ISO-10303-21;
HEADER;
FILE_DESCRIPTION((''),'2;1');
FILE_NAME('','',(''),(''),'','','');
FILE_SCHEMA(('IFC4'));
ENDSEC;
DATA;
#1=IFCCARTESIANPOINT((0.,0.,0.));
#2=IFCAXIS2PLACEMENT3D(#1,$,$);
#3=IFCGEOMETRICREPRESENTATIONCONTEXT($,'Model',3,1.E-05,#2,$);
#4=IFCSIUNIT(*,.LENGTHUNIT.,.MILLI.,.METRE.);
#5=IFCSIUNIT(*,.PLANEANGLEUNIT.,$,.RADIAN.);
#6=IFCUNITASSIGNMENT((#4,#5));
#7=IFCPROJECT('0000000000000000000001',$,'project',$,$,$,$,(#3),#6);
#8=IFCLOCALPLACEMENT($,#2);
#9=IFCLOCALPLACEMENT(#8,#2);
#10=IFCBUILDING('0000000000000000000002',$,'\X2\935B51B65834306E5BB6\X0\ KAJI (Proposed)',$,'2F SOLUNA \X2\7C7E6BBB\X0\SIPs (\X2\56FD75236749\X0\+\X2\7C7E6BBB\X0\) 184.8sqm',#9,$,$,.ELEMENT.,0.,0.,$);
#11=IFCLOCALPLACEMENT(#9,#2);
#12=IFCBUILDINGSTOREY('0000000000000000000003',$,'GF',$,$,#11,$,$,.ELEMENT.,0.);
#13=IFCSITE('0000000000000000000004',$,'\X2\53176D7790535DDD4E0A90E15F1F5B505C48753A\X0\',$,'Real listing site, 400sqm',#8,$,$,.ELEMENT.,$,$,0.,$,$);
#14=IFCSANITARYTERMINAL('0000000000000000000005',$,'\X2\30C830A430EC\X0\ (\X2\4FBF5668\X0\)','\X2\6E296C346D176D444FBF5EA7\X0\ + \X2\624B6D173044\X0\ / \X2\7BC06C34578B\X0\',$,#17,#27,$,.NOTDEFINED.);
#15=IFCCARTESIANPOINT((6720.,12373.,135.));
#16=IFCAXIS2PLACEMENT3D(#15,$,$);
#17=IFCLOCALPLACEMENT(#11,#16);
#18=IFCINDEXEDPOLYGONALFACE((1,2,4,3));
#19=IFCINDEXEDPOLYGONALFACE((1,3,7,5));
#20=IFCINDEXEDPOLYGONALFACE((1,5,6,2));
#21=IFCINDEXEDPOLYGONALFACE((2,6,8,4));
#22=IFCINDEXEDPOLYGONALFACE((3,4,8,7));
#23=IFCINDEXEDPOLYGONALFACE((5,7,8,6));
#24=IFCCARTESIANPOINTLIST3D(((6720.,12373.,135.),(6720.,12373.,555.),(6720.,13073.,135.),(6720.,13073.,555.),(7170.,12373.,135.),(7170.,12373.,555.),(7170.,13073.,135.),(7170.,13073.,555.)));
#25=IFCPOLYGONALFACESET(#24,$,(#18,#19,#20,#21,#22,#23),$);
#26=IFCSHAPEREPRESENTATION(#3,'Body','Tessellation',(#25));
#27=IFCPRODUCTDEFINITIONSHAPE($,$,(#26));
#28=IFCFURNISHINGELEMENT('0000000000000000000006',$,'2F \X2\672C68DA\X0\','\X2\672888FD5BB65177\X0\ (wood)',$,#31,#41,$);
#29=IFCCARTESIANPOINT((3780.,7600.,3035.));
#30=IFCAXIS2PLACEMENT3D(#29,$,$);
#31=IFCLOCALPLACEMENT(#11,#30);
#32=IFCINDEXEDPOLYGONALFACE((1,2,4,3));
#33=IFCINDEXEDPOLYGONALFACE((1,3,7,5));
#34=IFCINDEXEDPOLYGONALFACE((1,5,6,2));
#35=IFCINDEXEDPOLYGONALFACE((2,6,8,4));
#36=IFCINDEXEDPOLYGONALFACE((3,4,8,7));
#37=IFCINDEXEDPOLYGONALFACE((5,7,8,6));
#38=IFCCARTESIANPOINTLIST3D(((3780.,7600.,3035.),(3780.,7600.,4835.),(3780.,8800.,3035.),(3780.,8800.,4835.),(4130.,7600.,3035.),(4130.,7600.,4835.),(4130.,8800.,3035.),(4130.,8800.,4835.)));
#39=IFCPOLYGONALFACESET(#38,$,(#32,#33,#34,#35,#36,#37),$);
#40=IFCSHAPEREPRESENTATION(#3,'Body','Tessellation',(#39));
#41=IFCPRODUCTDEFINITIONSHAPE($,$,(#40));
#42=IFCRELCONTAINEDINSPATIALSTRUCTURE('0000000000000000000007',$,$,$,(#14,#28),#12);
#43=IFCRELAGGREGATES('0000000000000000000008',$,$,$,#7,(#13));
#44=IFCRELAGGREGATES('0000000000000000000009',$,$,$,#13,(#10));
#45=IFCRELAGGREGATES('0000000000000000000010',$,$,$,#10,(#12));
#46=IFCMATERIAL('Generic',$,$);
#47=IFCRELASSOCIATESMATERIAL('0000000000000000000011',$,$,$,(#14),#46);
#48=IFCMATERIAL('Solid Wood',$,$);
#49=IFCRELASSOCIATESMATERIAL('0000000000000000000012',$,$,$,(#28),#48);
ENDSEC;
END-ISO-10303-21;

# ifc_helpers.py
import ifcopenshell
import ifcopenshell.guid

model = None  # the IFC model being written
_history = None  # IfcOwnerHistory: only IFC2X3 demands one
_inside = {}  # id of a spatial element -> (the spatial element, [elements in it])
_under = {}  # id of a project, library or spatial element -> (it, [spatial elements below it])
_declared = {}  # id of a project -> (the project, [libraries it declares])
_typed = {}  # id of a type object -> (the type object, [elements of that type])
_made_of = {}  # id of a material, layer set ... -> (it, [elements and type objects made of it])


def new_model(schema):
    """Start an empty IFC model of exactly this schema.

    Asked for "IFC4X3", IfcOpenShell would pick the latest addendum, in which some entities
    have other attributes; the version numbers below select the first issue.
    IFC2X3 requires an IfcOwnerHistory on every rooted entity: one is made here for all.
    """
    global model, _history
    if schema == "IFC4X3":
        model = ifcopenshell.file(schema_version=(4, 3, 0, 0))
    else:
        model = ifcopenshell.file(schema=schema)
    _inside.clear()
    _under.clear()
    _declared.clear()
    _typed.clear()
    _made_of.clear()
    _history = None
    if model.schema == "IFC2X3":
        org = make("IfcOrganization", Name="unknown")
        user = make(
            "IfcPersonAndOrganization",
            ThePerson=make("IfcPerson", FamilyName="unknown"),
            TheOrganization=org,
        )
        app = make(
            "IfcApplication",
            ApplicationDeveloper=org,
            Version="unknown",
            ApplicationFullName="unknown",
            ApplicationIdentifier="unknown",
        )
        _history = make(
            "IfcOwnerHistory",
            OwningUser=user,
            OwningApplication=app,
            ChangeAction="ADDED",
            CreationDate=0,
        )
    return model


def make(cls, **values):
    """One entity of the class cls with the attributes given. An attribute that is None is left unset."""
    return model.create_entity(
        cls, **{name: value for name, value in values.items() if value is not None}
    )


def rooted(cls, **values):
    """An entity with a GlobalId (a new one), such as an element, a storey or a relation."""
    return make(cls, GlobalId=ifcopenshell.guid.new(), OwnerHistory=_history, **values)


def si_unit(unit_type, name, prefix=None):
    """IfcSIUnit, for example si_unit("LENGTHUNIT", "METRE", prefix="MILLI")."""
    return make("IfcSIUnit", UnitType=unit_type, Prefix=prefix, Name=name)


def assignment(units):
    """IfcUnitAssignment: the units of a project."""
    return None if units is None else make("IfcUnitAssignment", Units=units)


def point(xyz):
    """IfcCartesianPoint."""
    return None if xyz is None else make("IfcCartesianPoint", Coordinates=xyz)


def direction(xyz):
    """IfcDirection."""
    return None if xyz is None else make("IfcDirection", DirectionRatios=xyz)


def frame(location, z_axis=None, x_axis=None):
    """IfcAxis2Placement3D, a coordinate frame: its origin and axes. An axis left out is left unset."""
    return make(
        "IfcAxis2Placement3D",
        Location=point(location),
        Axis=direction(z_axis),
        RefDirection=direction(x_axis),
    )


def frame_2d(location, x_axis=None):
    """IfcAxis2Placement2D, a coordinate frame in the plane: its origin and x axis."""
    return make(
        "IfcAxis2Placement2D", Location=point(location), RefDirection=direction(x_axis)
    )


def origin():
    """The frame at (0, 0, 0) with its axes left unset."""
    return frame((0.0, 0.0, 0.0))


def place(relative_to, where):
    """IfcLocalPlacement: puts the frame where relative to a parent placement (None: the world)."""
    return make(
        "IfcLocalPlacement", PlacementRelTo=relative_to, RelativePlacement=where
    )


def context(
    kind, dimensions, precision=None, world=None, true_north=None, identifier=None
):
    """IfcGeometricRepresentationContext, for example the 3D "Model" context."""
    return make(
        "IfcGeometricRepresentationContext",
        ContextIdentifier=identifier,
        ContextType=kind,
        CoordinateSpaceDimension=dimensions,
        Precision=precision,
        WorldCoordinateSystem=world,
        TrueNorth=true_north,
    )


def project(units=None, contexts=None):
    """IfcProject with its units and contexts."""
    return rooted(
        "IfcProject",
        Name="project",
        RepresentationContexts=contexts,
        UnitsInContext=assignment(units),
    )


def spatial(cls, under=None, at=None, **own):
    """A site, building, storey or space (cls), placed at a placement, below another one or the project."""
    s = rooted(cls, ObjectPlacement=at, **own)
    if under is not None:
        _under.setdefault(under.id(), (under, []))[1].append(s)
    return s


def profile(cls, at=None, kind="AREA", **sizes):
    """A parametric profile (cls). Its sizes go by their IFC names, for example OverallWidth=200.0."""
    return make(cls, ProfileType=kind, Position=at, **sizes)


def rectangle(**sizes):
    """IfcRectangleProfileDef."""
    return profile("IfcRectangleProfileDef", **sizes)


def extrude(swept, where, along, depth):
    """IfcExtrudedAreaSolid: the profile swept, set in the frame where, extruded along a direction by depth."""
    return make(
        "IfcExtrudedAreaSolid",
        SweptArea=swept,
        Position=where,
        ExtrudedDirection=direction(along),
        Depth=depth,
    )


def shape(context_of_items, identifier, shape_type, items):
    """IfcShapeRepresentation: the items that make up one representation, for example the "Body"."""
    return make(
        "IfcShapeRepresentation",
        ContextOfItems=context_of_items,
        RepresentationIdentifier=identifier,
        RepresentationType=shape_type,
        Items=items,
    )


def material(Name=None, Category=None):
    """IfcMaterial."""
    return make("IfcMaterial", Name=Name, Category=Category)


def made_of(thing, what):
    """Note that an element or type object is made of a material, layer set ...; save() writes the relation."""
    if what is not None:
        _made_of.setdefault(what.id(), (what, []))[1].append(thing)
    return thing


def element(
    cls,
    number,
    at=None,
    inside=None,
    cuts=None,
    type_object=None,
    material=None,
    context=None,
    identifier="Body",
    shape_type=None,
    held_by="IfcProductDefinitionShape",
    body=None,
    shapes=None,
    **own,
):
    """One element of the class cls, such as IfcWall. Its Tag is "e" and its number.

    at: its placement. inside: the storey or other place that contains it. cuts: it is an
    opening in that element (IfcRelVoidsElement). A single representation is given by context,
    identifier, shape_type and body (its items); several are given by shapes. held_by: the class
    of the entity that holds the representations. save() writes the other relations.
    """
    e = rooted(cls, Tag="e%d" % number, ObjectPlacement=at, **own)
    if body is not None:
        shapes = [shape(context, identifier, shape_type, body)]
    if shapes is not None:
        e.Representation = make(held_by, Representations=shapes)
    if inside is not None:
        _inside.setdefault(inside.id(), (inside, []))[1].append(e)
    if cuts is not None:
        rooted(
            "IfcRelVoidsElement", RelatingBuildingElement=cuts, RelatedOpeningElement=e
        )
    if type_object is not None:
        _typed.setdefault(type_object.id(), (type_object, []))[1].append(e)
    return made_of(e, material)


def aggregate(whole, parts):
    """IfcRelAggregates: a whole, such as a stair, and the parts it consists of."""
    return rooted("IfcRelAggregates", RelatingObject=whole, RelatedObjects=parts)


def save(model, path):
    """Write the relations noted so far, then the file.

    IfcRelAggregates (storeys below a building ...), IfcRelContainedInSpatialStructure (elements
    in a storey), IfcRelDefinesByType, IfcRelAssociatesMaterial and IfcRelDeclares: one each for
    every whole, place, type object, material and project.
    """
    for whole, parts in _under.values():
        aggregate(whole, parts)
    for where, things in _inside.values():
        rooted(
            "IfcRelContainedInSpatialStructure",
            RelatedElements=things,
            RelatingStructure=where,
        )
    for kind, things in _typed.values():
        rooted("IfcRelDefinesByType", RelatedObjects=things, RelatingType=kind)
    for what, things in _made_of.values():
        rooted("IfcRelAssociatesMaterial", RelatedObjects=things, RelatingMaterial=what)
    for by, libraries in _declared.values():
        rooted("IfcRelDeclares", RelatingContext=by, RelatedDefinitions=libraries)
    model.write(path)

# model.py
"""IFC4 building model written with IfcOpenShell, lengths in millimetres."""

from ifc_helpers import new_model, si_unit, frame, frame_2d, origin, place, context, project, spatial, rectangle, extrude, material, element, save


model = new_model("IFC4")

# Units and contexts
model_context = context("Model", 3, precision=1e-05, world=origin())
ifc_project = project(units=[si_unit("LENGTHUNIT", "METRE", prefix="MILLI"), si_unit("PLANEANGLEUNIT", "RADIAN")], contexts=[model_context])

# Site, building, storey
site_placement = place(None, origin())
site = spatial("IfcSite", under=ifc_project, at=site_placement, Name="北海道川上郡弟子屈町", ObjectType="Real listing site, 400sqm", CompositionType="ELEMENT", RefElevation=0.0)
building_placement = place(site_placement, origin())
building = spatial("IfcBuilding", under=site, at=building_placement, Name="鍛冶場の家 KAJI (Proposed)", ObjectType="2F SOLUNA 籾殻SIPs (国産杉+籾殻) 184.8sqm", CompositionType="ELEMENT", ElevationOfRefHeight=0.0, ElevationOfTerrain=0.0)
storey_placement = place(building_placement, origin())
storey = spatial("IfcBuildingStorey", under=building, at=storey_placement, Name="GF", CompositionType="ELEMENT", Elevation=0.0)

# Shared definitions
ifc_material_1 = material(Name="Solid Wood")
ifc_material_2 = material(Name="Generic")

# Sanitary terminal
sanitary_terminal_1_placement = place(storey_placement, frame((6720.0, 12373.0, 135.0)))
element("IfcSanitaryTerminal", 1, at=sanitary_terminal_1_placement, inside=storey, material=ifc_material_2, Name="トイレ (便器)", Description="温水洗浄便座 + 手洗い / 節水型", PredefinedType="NOTDEFINED", context=model_context, shape_type="SweptSolid", body=[
    extrude(rectangle(XDim=450.0, YDim=700.0, at=frame_2d((225.0, 350.0))), frame((6720.0, 12373.0, 135.0)), (0.0, 0.0, 1.0), 420.0),
])

# Furnishing element
furnishing_placement = place(storey_placement, frame((3780.0, 7600.0, 3035.0)))
element("IfcFurnishingElement", 2, at=furnishing_placement, inside=storey, material=ifc_material_1, Name="2F 本棚", Description="木製家具 (wood)", context=model_context, shape_type="SweptSolid", body=[
    extrude(rectangle(XDim=350.0, YDim=1200.0, at=frame_2d((175.0, 600.0))), frame((3780.0, 7600.0, 3035.0)), (0.0, 0.0, 1.0), 1800.0),
])

save(model, "model.ifc")
